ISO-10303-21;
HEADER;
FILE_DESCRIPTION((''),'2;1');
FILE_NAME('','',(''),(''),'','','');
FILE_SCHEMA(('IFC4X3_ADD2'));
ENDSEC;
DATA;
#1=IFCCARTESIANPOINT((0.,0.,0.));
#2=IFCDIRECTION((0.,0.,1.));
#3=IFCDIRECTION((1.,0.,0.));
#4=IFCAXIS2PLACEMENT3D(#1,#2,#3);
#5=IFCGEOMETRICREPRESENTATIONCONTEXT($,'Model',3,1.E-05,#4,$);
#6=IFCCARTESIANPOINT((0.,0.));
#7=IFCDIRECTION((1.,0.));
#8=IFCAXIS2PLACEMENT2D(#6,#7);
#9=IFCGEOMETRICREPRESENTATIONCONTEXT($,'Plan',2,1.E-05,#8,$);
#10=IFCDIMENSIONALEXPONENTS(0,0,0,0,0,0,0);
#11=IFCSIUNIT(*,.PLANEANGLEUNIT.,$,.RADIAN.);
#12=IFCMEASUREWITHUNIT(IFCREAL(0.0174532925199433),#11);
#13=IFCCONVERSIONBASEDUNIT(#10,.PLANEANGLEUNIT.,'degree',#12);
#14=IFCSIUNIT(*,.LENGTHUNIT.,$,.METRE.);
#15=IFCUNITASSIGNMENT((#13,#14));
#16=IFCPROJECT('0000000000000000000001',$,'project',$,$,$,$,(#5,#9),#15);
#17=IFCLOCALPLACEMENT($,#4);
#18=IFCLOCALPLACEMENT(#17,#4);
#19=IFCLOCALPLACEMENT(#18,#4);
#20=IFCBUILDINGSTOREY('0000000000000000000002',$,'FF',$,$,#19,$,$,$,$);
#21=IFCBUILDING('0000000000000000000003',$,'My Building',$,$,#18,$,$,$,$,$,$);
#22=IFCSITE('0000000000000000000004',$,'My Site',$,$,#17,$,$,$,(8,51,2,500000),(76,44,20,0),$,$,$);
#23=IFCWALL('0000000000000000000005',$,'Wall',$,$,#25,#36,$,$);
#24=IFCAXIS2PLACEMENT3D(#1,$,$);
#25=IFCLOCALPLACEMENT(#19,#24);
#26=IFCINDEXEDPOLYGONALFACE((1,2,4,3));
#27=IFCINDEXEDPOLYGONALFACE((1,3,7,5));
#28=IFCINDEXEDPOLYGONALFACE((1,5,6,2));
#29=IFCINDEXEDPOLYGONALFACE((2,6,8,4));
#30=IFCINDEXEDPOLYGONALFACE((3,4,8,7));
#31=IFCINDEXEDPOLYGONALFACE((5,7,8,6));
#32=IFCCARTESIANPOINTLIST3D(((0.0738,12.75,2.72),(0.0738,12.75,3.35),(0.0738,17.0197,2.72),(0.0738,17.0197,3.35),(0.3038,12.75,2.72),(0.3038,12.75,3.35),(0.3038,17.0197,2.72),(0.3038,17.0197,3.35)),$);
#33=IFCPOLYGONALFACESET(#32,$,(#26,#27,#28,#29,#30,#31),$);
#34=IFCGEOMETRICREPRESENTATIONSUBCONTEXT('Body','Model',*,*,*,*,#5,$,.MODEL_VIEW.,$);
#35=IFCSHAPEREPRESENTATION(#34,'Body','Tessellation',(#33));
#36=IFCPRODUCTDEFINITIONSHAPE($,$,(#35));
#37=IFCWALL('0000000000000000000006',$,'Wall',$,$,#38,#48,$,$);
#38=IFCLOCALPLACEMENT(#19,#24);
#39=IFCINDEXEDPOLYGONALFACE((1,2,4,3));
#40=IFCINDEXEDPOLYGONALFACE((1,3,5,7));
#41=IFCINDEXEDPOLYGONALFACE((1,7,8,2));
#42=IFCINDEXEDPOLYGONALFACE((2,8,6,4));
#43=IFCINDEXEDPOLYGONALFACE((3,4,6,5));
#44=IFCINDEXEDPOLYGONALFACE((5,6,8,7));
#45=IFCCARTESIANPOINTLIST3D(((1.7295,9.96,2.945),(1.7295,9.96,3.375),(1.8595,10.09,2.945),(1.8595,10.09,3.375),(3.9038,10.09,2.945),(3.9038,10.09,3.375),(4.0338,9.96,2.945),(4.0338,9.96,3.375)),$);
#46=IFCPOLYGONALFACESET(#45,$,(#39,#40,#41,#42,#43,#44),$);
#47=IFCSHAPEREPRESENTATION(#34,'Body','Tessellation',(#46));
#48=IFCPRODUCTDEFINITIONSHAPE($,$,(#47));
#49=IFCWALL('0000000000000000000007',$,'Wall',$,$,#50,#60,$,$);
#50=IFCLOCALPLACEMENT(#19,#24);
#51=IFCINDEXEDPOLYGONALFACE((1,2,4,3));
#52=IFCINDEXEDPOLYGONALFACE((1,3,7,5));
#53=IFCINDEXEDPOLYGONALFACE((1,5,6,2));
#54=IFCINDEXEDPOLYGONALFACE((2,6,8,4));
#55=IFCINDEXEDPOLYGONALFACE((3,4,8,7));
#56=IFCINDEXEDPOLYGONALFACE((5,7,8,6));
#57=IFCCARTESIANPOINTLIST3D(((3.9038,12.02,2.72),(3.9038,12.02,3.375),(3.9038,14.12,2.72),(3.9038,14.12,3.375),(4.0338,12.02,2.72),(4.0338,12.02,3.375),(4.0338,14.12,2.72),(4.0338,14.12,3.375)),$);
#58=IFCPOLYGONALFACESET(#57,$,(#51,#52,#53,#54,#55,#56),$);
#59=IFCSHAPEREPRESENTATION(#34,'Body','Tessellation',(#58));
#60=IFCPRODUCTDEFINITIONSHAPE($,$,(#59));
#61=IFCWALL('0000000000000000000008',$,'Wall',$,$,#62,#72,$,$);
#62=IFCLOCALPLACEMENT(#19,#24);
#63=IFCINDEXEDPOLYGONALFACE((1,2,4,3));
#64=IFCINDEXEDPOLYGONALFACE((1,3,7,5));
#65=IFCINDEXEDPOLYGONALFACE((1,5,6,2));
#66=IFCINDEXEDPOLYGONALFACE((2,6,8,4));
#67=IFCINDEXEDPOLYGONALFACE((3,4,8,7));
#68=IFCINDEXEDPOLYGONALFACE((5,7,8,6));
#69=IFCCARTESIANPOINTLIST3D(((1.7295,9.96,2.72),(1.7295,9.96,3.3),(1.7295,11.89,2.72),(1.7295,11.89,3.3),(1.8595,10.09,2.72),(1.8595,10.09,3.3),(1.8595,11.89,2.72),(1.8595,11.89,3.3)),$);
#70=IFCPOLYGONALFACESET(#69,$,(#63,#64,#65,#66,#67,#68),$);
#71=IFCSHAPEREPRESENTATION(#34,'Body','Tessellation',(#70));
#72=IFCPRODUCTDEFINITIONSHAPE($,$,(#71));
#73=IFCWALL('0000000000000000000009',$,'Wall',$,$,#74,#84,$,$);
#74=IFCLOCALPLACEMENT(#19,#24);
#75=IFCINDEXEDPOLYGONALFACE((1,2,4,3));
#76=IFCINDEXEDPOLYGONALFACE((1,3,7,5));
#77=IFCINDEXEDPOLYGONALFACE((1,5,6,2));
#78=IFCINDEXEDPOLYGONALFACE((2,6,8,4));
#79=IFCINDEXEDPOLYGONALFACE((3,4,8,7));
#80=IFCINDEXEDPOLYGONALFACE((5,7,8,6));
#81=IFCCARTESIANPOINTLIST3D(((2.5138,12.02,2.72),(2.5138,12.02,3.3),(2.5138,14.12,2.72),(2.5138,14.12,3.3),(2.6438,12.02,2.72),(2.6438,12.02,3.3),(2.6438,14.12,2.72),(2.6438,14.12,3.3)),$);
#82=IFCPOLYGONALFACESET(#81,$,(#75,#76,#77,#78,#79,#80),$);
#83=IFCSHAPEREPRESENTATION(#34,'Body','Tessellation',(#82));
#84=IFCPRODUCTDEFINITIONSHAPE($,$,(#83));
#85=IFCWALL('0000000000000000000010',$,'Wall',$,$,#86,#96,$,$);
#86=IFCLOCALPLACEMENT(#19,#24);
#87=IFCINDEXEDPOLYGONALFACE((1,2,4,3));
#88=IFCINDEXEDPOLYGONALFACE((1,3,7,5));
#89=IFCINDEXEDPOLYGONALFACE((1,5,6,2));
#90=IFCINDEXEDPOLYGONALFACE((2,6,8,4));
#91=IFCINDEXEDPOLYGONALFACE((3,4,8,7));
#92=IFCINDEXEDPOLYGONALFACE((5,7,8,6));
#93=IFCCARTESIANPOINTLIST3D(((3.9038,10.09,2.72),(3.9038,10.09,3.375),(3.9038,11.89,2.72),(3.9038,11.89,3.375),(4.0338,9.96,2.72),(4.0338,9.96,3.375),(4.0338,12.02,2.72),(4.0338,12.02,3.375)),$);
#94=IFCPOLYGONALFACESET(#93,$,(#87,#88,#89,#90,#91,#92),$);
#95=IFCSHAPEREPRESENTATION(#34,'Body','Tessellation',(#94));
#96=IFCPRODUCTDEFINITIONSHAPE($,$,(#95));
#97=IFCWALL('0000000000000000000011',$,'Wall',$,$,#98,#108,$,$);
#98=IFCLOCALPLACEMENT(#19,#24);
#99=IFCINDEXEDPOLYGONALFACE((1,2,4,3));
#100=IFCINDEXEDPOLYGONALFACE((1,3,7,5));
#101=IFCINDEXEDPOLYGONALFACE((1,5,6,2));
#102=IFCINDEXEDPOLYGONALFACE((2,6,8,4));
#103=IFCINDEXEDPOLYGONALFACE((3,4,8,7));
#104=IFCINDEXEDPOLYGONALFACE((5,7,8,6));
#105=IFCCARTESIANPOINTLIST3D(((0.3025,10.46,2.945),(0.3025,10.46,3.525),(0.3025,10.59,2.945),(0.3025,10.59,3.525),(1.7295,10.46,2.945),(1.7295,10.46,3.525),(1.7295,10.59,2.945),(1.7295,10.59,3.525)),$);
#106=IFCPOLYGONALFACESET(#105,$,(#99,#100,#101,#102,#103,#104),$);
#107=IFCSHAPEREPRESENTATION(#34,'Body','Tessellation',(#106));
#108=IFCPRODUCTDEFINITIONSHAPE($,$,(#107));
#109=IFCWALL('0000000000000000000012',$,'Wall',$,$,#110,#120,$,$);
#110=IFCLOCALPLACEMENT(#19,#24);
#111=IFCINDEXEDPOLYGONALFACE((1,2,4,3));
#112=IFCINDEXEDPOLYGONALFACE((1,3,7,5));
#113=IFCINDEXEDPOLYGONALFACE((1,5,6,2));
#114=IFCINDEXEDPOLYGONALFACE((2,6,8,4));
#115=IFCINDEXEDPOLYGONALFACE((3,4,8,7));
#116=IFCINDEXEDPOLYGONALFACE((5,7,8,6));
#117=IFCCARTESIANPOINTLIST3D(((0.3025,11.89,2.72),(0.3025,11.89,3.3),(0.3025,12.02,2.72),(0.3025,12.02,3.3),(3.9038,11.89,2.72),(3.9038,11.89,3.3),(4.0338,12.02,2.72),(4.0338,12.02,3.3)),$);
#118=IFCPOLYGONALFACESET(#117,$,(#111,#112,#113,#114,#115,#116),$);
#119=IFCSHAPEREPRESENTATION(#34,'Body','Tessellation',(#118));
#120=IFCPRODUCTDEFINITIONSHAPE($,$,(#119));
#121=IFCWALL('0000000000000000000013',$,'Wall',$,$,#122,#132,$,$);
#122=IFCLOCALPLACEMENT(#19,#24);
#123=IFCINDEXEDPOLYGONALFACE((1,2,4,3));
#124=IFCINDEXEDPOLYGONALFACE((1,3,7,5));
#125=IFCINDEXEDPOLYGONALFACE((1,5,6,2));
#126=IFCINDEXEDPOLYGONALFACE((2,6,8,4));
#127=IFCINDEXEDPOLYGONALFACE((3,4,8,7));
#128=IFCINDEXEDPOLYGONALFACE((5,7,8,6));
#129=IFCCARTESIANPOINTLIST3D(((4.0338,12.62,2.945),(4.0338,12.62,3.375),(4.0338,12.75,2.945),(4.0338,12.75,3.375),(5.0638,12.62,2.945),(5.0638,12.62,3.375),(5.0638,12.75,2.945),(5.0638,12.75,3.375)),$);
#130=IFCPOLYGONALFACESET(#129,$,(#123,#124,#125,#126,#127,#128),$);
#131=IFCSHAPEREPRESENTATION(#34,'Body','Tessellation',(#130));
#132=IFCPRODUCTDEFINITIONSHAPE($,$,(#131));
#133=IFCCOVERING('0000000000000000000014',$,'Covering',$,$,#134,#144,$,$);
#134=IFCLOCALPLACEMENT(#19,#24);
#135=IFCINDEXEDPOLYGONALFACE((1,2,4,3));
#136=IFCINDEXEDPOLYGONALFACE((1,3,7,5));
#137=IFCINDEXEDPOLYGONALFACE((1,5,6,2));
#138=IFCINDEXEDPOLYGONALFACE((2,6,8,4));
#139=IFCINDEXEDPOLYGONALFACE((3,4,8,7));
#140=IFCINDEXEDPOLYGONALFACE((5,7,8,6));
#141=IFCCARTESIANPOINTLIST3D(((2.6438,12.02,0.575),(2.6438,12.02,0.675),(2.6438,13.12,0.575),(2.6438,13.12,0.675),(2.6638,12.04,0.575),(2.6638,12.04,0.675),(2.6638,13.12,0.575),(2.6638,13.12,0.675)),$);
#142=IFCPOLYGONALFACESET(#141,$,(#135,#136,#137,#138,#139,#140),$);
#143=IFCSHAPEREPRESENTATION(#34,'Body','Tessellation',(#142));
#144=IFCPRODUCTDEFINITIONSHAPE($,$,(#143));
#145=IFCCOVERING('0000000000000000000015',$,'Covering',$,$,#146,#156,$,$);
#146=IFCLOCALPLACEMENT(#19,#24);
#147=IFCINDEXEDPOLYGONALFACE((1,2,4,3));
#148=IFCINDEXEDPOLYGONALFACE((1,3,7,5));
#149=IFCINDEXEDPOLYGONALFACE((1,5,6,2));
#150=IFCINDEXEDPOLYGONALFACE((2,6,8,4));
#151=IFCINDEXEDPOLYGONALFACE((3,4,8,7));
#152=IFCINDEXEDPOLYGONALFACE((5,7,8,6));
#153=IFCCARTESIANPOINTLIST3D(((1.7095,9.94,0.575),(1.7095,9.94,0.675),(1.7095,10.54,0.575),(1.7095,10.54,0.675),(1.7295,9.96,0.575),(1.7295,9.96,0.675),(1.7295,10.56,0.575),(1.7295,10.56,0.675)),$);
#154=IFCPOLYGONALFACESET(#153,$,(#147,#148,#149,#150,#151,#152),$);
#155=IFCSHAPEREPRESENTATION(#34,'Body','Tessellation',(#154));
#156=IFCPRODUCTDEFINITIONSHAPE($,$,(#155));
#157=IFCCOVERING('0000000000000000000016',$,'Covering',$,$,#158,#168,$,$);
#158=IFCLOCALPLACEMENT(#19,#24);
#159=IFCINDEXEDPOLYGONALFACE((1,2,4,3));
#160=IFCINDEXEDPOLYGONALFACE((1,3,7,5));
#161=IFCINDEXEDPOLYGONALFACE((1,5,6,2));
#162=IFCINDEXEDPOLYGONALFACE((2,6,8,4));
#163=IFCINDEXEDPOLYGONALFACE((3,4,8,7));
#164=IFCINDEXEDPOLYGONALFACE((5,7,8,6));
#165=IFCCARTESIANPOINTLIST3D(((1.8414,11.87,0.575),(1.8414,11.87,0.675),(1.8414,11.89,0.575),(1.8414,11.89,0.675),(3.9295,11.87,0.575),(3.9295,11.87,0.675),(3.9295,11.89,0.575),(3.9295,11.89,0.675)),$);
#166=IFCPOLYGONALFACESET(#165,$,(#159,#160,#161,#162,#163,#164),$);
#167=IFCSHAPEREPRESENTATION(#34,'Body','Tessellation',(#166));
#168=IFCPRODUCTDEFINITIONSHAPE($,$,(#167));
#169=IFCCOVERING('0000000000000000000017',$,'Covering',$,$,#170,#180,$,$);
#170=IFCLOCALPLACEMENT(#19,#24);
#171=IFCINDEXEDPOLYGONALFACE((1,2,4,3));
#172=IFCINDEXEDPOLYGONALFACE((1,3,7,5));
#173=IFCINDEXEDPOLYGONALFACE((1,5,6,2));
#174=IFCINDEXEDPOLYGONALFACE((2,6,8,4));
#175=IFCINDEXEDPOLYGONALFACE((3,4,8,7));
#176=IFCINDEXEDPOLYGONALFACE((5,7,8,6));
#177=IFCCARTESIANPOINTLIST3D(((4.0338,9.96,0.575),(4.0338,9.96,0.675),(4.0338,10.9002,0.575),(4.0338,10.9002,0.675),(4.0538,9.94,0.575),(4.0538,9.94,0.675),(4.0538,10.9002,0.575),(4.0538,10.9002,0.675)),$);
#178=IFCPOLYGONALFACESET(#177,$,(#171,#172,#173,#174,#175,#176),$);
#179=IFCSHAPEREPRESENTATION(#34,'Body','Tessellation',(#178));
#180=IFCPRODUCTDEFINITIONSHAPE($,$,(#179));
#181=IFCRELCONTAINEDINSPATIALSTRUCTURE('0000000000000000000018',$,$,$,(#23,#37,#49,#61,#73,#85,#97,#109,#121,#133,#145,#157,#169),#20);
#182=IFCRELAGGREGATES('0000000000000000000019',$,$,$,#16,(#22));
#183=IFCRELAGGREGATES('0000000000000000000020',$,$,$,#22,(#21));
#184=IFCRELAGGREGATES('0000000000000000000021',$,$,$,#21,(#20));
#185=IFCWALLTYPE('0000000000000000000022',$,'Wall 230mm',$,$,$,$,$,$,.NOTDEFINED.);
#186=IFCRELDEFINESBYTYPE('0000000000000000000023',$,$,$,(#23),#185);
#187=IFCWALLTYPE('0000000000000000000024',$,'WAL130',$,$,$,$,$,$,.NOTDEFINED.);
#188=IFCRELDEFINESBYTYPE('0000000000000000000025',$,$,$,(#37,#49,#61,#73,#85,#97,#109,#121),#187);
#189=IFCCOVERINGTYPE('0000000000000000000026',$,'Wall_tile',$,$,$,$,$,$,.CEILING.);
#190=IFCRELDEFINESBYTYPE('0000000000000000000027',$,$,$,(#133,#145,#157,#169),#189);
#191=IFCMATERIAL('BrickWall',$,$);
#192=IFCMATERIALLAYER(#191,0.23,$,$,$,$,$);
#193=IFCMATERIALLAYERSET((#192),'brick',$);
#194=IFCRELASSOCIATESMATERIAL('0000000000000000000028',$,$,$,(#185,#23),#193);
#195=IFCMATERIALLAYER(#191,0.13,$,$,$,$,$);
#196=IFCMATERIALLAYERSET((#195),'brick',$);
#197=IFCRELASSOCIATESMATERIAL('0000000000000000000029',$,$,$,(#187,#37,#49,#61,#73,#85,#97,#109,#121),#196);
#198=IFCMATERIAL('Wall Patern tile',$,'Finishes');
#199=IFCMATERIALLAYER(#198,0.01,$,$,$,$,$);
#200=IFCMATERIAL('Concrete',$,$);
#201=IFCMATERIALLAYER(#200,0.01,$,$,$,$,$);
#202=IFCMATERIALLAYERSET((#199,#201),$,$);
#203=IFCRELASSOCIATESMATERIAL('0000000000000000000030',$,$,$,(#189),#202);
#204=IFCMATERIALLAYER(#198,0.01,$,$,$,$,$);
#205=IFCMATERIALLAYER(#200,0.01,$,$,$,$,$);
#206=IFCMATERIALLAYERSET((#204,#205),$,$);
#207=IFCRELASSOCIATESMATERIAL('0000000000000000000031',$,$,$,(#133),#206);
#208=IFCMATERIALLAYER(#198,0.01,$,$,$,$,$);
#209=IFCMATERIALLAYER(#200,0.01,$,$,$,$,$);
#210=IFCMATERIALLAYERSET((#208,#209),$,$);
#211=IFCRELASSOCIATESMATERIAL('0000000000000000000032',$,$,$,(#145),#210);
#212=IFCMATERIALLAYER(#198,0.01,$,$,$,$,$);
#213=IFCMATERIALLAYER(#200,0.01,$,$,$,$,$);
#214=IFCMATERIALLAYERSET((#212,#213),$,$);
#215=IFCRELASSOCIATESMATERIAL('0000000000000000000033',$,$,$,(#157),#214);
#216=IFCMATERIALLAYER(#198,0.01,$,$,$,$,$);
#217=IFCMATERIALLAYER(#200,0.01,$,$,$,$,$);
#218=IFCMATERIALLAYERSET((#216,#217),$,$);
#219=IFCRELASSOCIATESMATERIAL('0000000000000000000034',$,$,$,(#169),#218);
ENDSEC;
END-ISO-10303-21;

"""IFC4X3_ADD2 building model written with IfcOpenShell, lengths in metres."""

from ifc_helpers import new_model, entity, si_unit, converted_unit, frame, origin_with_axes, origin_2d_with_axis, place, context, subcontext, project, spatial, line, indexed_curve, outline, extrude, material, layer, layer_set, layer_usage, type_object, element, save


model = new_model("IFC4X3_ADD2")

# Units and contexts
model_context = context("Model", 3, precision=1e-05, world=origin_with_axes())
plan_context = context("Plan", 2, precision=1e-05, world=origin_2d_with_axis())
body_context = subcontext(model_context, "Body", "Model", "MODEL_VIEW")
ifc_project = project(units=[converted_unit("PLANEANGLEUNIT", "degree", entity("IfcReal", 0.0174532925199433), si_unit("PLANEANGLEUNIT", "RADIAN"), dimensions=[0, 0, 0, 0, 0, 0, 0]), si_unit("LENGTHUNIT", "METRE")], contexts=[model_context, plan_context])

# Site, building, storey
site_placement = place(None, origin_with_axes())
site = spatial("IfcSite", under=ifc_project, at=site_placement, Name="My Site", RefLatitude=(8, 51, 2, 500000), RefLongitude=(76, 44, 20, 0))
building_placement = place(site_placement, origin_with_axes())
building = spatial("IfcBuilding", under=site, at=building_placement, Name="My Building")
storey_placement = place(building_placement, origin_with_axes())
storey = spatial("IfcBuildingStorey", under=building, at=storey_placement, Name="FF")

# Walls
ifc_material_1 = material(Name="BrickWall")
ifc_layer_1 = layer(ifc_material_1, 0.23)
ifc_layer_set_1 = layer_set([ifc_layer_1], Name="brick")
ifc_layer_usage_1 = layer_usage(ifc_layer_set_1, "AXIS2", "POSITIVE", 0.0)
wall_type_1 = type_object("IfcWallType", Name="Wall 230mm", PredefinedType="NOTDEFINED", material=ifc_layer_set_1)
wall_1_placement = place(storey_placement, frame((0.3038, 12.75, 2.72), z_axis=(0.0, 0.0, 1.0), x_axis=(0.0, 1.0, 0.0)))
element("IfcWall", 1, at=wall_1_placement, inside=storey, type_object=wall_type_1, material=ifc_layer_usage_1, Name="Wall", context=body_context, shape_type="SweptSolid", body=[
    extrude(outline(indexed_curve([(0.0, 0.0), (0.0, 0.23), (4.2697, 0.23), (4.2697, 0.0)], segments=[line(1, 2, 3, 4, 1)])), origin_with_axes(), (0.0, 0.0, 1.0), 0.63),
])
ifc_layer_2 = layer(ifc_material_1, 0.13)
ifc_layer_set_2 = layer_set([ifc_layer_2], Name="brick")
ifc_layer_usage_2 = layer_usage(ifc_layer_set_2, "AXIS2", "POSITIVE", 0.0)
wall_type_2 = type_object("IfcWallType", Name="WAL130", PredefinedType="NOTDEFINED", material=ifc_layer_set_2)
wall_2_placement = place(storey_placement, frame((1.8595, 9.96, 2.945), z_axis=(0.0, 0.0, 1.0), x_axis=(1.0, 0.0, 0.0)))
element("IfcWall", 2, at=wall_2_placement, inside=storey, type_object=wall_type_2, material=ifc_layer_usage_2, Name="Wall", context=body_context, shape_type="SweptSolid", body=[
    extrude(outline(indexed_curve([(-0.13, 0.0), (0.0, 0.13), (2.0444, 0.13), (2.1744, 0.0)], segments=[line(1, 2, 3, 4, 1)])), origin_with_axes(), (0.0, 0.0, 1.0), 0.43),
])
ifc_layer_usage_3 = layer_usage(ifc_layer_set_2, "AXIS2", "POSITIVE", 0.0)
wall_3_placement = place(storey_placement, frame((4.0338, 12.02, 2.72), z_axis=(0.0, 0.0, 1.0), x_axis=(0.0, 1.0, 0.0)))
element("IfcWall", 3, at=wall_3_placement, inside=storey, type_object=wall_type_2, material=ifc_layer_usage_3, Name="Wall", context=body_context, shape_type="SweptSolid", body=[
    extrude(outline(indexed_curve([(0.0, 0.0), (0.0, 0.13), (2.1, 0.13), (2.1, 0.0)], segments=[line(1, 2, 3, 4, 1)])), origin_with_axes(), (0.0, 0.0, 1.0), 0.655),
])
ifc_layer_usage_4 = layer_usage(ifc_layer_set_2, "AXIS2", "POSITIVE", 0.0)
wall_4_placement = place(storey_placement, frame((1.8595, 9.96, 2.72), z_axis=(0.0, 0.0, 1.0), x_axis=(0.0, 1.0, 0.0)))
element("IfcWall", 4, at=wall_4_placement, inside=storey, type_object=wall_type_2, material=ifc_layer_usage_4, Name="Wall", context=body_context, shape_type="SweptSolid", body=[
    extrude(outline(indexed_curve([(0.13, 0.0), (0.0, 0.13), (1.93, 0.13), (1.93, 0.0)], segments=[line(1, 2, 3, 4, 1)])), origin_with_axes(), (0.0, 0.0, 1.0), 0.58),
])
ifc_layer_usage_5 = layer_usage(ifc_layer_set_2, "AXIS2", "POSITIVE", 0.0)
wall_5_placement = place(storey_placement, frame((2.6438, 12.02, 2.72), z_axis=(0.0, 0.0, 1.0), x_axis=(0.0, 1.0, 0.0)))
element("IfcWall", 5, at=wall_5_placement, inside=storey, type_object=wall_type_2, material=ifc_layer_usage_5, Name="Wall", context=body_context, shape_type="SweptSolid", body=[
    extrude(outline(indexed_curve([(0.0, 0.0), (0.0, 0.13), (2.1, 0.13), (2.1, 0.0)], segments=[line(1, 2, 3, 4, 1)])), origin_with_axes(), (0.0, 0.0, 1.0), 0.58),
])
ifc_layer_usage_6 = layer_usage(ifc_layer_set_2, "AXIS2", "POSITIVE", 0.0)
wall_6_placement = place(storey_placement, frame((4.0338, 9.96, 2.72), z_axis=(0.0, 0.0, 1.0), x_axis=(0.0, 1.0, 0.0)))
element("IfcWall", 6, at=wall_6_placement, inside=storey, type_object=wall_type_2, material=ifc_layer_usage_6, Name="Wall", context=body_context, shape_type="SweptSolid", body=[
    extrude(outline(indexed_curve([(0.0, 0.0), (0.13, 0.13), (1.93, 0.13), (2.06, 0.0)], segments=[line(1, 2, 3, 4, 1)])), origin_with_axes(), (0.0, 0.0, 1.0), 0.655),
])
ifc_layer_usage_7 = layer_usage(ifc_layer_set_2, "AXIS2", "POSITIVE", 0.0)
wall_7_placement = place(storey_placement, frame((0.3025, 10.46, 2.945), z_axis=(0.0, 0.0, 1.0), x_axis=(1.0, 0.0, 0.0)))
element("IfcWall", 7, at=wall_7_placement, inside=storey, type_object=wall_type_2, material=ifc_layer_usage_7, Name="Wall", context=body_context, shape_type="SweptSolid", body=[
    extrude(outline(indexed_curve([(0.0, 0.0), (0.0, 0.13), (1.427, 0.13), (1.427, 0.0), (0.0, 0.0)], self_intersect=False)), origin_with_axes(), (0.0, 0.0, 1.0), 0.58),
])
ifc_layer_usage_8 = layer_usage(ifc_layer_set_2, "AXIS2", "POSITIVE", 0.0)
wall_8_placement = place(storey_placement, frame((0.3025, 11.89, 2.72), z_axis=(0.0, 0.0, 1.0), x_axis=(1.0, 0.0, 0.0)))
element("IfcWall", 8, at=wall_8_placement, inside=storey, type_object=wall_type_2, material=ifc_layer_usage_8, Name="Wall", context=body_context, shape_type="SweptSolid", body=[
    extrude(outline(indexed_curve([(0.0, 0.0), (0.0, 0.13), (3.7313, 0.13), (3.6013, 0.0)], segments=[line(1, 2, 3, 4, 1)])), origin_with_axes(), (0.0, 0.0, 1.0), 0.58),
])
ifc_layer_usage_9 = layer_usage(ifc_layer_set_2, "AXIS2", "POSITIVE", 0.0)
wall_9_placement = place(storey_placement, frame((4.0338, 12.62, 2.945), z_axis=(0.0, 0.0, 1.0), x_axis=(1.0, 0.0, 0.0)))
element("IfcWall", 9, at=wall_9_placement, inside=storey, type_object=wall_type_2, material=ifc_layer_usage_9, Name="Wall", context=body_context, shape_type="SweptSolid", body=[
    extrude(outline(indexed_curve([(0.0, 0.0), (0.0, 0.13), (1.03, 0.13), (1.03, 0.0)], segments=[line(1, 2, 3, 4, 1)])), origin_with_axes(), (0.0, 0.0, 1.0), 0.43),
])

# Coverings
ifc_material_2 = material(Name="Wall Patern tile", Category="Finishes")
ifc_layer_3 = layer(ifc_material_2, 0.01)
ifc_material_3 = material(Name="Concrete")
ifc_layer_4 = layer(ifc_material_3, 0.01)
ifc_layer_set_3 = layer_set([ifc_layer_3, ifc_layer_4])
ifc_layer_usage_10 = layer_usage(ifc_layer_set_3, "AXIS2", "NEGATIVE", 0.0)
ifc_layer_5 = layer(ifc_material_2, 0.01)
ifc_layer_6 = layer(ifc_material_3, 0.01)
ifc_layer_set_4 = layer_set([ifc_layer_5, ifc_layer_6])
covering_type = type_object("IfcCoveringType", Name="Wall_tile", PredefinedType="CEILING", material=ifc_layer_set_4)
covering_1_placement = place(storey_placement, frame((2.6638, 13.12, 0.575), z_axis=(0.0, 0.0, 1.0), x_axis=(0.0, -1.0, 0.0)))
element("IfcCovering", 10, at=covering_1_placement, inside=storey, type_object=covering_type, material=ifc_layer_usage_10, Name="Covering", context=body_context, shape_type="SweptSolid", body=[
    extrude(outline(indexed_curve([(0.0, -0.02), (0.0, 0.0), (1.08, 0.0), (1.1, -0.02)], segments=[line(1, 2, 3, 4, 1)])), origin_with_axes(), (0.0, 0.0, 1.0), 0.1),
])
ifc_layer_7 = layer(ifc_material_2, 0.01)
ifc_layer_8 = layer(ifc_material_3, 0.01)
ifc_layer_set_5 = layer_set([ifc_layer_7, ifc_layer_8])
ifc_layer_usage_11 = layer_usage(ifc_layer_set_5, "AXIS2", "POSITIVE", 0.0)
covering_2_placement = place(storey_placement, frame((1.7095, 10.54, 0.575), z_axis=(0.0, 0.0, 1.0), x_axis=(0.0, -1.0, 0.0)))
element("IfcCovering", 11, at=covering_2_placement, inside=storey, type_object=covering_type, material=ifc_layer_usage_11, Name="Covering", context=body_context, shape_type="SweptSolid", body=[
    extrude(outline(indexed_curve([(0.0, 0.0), (-0.02, 0.02), (0.58, 0.02), (0.6, 0.0)], segments=[line(1, 2, 3, 4, 1)])), origin_with_axes(), (0.0, 0.0, 1.0), 0.1),
])
ifc_layer_9 = layer(ifc_material_2, 0.01)
ifc_layer_10 = layer(ifc_material_3, 0.01)
ifc_layer_set_6 = layer_set([ifc_layer_9, ifc_layer_10])
ifc_layer_usage_12 = layer_usage(ifc_layer_set_6, "AXIS2", "POSITIVE", 0.0)
covering_3_placement = place(storey_placement, frame((1.8414, 11.87, 0.575), z_axis=(0.0, 0.0, 1.0), x_axis=(1.0, 0.0, 0.0)))
element("IfcCovering", 12, at=covering_3_placement, inside=storey, type_object=covering_type, material=ifc_layer_usage_12, Name="Covering", context=body_context, shape_type="SweptSolid", body=[
    extrude(outline(indexed_curve([(0.0, 0.0), (0.0, 0.02), (2.0881, 0.02), (2.0881, 0.0)], segments=[line(1, 2, 3, 4, 1)])), origin_with_axes(), (0.0, 0.0, 1.0), 0.1),
])
ifc_layer_11 = layer(ifc_material_2, 0.01)
ifc_layer_12 = layer(ifc_material_3, 0.01)
ifc_layer_set_7 = layer_set([ifc_layer_11, ifc_layer_12])
ifc_layer_usage_13 = layer_usage(ifc_layer_set_7, "AXIS2", "NEGATIVE", 0.0)
covering_4_placement = place(storey_placement, frame((4.0538, 10.9002, 0.575), z_axis=(0.0, 0.0, 1.0), x_axis=(0.0, -1.0, 0.0)))
element("IfcCovering", 13, at=covering_4_placement, inside=storey, type_object=covering_type, material=ifc_layer_usage_13, Name="Covering", context=body_context, shape_type="SweptSolid", body=[
    extrude(outline(indexed_curve([(0.0, -0.02), (0.0, 0.0), (0.9602, 0.0), (0.9402, -0.02)], segments=[line(1, 2, 3, 4, 1)])), origin_with_axes(), (0.0, 0.0, 1.0), 0.1),
])

save(model, "model.ifc")
